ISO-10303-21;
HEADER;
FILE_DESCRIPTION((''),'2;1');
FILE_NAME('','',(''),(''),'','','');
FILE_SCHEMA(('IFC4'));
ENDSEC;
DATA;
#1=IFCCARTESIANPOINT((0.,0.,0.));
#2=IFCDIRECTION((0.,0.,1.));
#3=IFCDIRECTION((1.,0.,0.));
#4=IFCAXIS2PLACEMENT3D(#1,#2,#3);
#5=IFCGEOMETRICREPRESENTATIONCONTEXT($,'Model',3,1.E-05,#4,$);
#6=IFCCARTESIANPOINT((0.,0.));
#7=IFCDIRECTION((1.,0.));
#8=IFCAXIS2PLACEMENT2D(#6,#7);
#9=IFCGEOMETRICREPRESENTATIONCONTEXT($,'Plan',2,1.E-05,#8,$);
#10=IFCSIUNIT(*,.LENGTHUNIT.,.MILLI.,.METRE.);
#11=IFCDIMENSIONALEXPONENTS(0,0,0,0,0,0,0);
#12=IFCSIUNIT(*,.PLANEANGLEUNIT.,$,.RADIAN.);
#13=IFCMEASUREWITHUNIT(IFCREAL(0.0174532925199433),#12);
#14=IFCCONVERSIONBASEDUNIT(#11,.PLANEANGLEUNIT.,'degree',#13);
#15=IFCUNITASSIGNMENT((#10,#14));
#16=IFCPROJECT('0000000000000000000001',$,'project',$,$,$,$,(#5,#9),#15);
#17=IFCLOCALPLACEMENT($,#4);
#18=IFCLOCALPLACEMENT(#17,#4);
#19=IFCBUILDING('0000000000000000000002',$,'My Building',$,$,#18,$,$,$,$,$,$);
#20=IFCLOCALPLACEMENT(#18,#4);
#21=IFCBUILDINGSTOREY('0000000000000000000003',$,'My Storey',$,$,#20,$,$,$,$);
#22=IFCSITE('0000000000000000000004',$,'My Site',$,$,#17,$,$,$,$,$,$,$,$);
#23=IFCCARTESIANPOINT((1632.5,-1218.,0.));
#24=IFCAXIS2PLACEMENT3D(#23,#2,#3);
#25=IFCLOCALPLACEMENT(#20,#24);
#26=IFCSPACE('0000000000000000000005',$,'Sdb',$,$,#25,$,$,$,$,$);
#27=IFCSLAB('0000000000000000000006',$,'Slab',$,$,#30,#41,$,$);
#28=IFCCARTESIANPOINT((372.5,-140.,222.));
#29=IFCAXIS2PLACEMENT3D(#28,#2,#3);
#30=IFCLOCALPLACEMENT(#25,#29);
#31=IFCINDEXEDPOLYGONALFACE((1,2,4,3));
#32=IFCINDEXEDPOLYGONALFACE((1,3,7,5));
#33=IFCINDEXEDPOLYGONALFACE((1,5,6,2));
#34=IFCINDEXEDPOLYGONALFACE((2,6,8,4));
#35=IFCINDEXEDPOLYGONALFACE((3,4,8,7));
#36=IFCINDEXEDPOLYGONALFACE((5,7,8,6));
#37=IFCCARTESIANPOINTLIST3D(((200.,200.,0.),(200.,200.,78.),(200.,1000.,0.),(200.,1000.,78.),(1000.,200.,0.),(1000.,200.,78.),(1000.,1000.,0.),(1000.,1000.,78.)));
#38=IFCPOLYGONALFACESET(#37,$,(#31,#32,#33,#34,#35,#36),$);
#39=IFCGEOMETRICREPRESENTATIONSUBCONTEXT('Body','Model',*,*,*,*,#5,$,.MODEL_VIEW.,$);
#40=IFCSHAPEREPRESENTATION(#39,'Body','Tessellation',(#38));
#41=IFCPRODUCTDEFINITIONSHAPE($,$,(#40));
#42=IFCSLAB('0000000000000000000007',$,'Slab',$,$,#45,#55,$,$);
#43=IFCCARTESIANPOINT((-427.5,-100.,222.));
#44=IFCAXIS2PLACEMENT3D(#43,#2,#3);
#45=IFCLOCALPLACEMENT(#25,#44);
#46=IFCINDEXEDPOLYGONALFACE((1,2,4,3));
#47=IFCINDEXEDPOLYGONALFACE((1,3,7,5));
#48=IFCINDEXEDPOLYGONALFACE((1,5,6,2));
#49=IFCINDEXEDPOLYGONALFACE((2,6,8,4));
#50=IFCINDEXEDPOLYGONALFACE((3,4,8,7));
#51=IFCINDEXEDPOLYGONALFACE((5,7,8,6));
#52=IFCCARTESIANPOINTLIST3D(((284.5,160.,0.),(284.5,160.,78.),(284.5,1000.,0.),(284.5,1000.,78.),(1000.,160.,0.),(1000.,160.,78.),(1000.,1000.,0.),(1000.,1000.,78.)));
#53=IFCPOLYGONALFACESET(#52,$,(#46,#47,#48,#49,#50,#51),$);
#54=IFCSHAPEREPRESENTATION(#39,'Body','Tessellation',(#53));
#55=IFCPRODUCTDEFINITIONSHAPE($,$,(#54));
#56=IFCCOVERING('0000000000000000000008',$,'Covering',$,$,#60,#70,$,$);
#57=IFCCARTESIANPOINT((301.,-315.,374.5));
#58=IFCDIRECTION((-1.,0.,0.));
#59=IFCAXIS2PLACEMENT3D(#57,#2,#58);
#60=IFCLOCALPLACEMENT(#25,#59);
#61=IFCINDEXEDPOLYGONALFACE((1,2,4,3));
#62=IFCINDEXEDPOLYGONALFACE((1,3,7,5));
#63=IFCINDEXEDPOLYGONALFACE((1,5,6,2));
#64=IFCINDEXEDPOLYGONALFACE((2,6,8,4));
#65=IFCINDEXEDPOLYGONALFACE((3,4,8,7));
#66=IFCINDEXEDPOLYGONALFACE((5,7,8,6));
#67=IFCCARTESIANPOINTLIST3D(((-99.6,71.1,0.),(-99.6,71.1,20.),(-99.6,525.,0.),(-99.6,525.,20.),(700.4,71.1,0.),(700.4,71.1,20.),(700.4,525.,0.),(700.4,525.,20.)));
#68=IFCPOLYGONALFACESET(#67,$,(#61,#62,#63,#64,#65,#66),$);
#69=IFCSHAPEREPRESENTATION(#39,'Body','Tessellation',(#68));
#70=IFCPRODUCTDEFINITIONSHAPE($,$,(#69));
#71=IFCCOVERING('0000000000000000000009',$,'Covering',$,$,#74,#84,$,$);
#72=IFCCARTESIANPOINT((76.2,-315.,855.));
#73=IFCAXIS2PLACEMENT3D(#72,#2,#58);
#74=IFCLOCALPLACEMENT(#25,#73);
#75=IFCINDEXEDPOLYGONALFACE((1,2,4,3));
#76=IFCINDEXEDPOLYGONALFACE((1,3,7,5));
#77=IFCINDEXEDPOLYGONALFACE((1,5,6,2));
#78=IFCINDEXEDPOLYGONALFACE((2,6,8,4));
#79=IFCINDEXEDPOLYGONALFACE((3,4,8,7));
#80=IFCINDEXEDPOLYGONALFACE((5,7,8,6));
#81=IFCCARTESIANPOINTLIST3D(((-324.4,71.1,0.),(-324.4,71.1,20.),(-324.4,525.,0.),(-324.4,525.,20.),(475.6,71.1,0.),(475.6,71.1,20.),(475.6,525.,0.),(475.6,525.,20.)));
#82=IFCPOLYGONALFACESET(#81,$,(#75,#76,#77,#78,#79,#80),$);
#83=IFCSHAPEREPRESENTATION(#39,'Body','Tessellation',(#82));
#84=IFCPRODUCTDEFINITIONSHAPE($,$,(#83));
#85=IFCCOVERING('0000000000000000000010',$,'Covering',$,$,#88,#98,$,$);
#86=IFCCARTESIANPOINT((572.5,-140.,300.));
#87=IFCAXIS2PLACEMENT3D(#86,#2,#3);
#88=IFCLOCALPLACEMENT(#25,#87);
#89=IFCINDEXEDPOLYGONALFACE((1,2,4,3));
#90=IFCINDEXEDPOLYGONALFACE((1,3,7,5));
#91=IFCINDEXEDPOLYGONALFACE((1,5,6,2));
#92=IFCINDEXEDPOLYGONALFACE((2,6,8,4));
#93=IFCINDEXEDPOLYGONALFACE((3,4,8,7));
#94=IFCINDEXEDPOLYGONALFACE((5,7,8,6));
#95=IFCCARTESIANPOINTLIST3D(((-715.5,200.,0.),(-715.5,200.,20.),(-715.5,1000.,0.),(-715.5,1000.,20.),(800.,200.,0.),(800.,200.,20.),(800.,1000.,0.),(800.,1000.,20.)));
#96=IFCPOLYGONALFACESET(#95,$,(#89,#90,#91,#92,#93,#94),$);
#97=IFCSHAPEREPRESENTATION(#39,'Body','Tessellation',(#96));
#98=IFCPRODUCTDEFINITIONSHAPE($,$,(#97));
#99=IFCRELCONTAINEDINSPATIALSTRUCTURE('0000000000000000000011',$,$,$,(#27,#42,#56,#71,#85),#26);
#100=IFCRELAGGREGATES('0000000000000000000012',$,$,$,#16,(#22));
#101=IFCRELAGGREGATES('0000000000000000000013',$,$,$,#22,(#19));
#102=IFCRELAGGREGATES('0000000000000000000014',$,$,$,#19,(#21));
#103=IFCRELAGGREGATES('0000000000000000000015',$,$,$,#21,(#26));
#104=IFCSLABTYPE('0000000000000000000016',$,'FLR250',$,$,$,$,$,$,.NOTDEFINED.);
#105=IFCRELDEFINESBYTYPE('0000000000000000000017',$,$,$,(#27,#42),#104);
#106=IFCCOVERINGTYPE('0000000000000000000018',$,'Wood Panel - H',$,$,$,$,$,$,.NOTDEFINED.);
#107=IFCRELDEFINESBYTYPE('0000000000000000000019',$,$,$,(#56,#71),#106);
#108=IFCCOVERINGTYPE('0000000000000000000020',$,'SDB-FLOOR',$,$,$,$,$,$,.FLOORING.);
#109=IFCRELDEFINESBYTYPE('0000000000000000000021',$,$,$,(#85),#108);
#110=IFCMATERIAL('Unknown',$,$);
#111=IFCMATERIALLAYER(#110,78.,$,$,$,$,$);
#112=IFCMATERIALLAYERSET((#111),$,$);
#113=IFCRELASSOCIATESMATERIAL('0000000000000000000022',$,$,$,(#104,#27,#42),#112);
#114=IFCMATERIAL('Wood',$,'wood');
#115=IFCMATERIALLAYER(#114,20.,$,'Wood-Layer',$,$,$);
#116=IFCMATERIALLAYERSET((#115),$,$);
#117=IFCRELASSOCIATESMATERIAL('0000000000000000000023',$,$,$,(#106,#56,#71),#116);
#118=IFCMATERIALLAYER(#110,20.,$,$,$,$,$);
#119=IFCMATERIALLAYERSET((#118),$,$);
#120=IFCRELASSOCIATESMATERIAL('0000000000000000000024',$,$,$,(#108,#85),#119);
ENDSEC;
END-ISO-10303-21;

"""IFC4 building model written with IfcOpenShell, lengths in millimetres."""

from ifc_helpers import new_model, entity, si_unit, converted_unit, frame, origin_with_axes, origin_2d_with_axis, place, context, subcontext, project, spatial, line, indexed_curve, outline, extrude, material, layer, layer_set, layer_usage, type_object, element, save


model = new_model("IFC4")

# Units and contexts
model_context = context("Model", 3, precision=1e-05, world=origin_with_axes())
plan_context = context("Plan", 2, precision=1e-05, world=origin_2d_with_axis())
body_context = subcontext(model_context, "Body", "Model", "MODEL_VIEW")
ifc_project = project(units=[si_unit("LENGTHUNIT", "METRE", prefix="MILLI"), converted_unit("PLANEANGLEUNIT", "degree", entity("IfcReal", 0.0174532925199433), si_unit("PLANEANGLEUNIT", "RADIAN"), dimensions=[0, 0, 0, 0, 0, 0, 0])], contexts=[model_context, plan_context])

# Site, building, storey, space
site_placement = place(None, origin_with_axes())
site = spatial("IfcSite", under=ifc_project, at=site_placement, Name="My Site")
building_placement = place(site_placement, origin_with_axes())
building = spatial("IfcBuilding", under=site, at=building_placement, Name="My Building")
storey_placement = place(building_placement, origin_with_axes())
storey = spatial("IfcBuildingStorey", under=building, at=storey_placement, Name="My Storey")
space_placement = place(storey_placement, frame((1632.5, -1218.0, 0.0), z_axis=(0.0, 0.0, 1.0), x_axis=(1.0, 0.0, 0.0)))
space = spatial("IfcSpace", under=storey, at=space_placement, Name="Sdb")

# Slabs
ifc_material_1 = material(Name="Unknown")
ifc_layer_1 = layer(ifc_material_1, 78.0)
ifc_layer_set_1 = layer_set([ifc_layer_1])
ifc_layer_usage_1 = layer_usage(ifc_layer_set_1, "AXIS3", "POSITIVE", 0.0)
slab_type = type_object("IfcSlabType", Name="FLR250", PredefinedType="NOTDEFINED", material=ifc_layer_set_1)
slab_1_placement = place(space_placement, frame((372.5, -140.0, 222.0), z_axis=(0.0, 0.0, 1.0), x_axis=(1.0, 0.0, 0.0)))
element("IfcSlab", 1, at=slab_1_placement, inside=space, type_object=slab_type, material=ifc_layer_usage_1, Name="Slab", context=body_context, shape_type="SweptSolid", body=[
    extrude(outline(indexed_curve([(1000.0, 200.0), (200.0, 200.0), (200.0, 1000.0), (1000.0, 1000.0)], segments=[line(4, 1), line(1, 2), line(2, 3), line(3, 4)], self_intersect=False)), None, (0.0, 0.0, 1.0), 78.0),
])
ifc_layer_usage_2 = layer_usage(ifc_layer_set_1, "AXIS3", "POSITIVE", 0.0)
slab_2_placement = place(space_placement, frame((-427.5, -100.0, 222.0), z_axis=(0.0, 0.0, 1.0), x_axis=(1.0, 0.0, 0.0)))
element("IfcSlab", 2, at=slab_2_placement, inside=space, type_object=slab_type, material=ifc_layer_usage_2, Name="Slab", context=body_context, shape_type="SolidModel", body=[
    extrude(outline(indexed_curve([(284.5, 1000.0), (284.5, 160.0), (1000.0, 160.0), (1000.0, 1000.0), (284.5, 1000.0)])), None, (0.0, 0.0, 1.0), 78.0),
])

# Coverings
ifc_material_2 = material(Name="Wood", Category="wood")
ifc_layer_2 = layer(ifc_material_2, 20.0, Name="Wood-Layer")
ifc_layer_set_2 = layer_set([ifc_layer_2])
ifc_layer_usage_3 = layer_usage(ifc_layer_set_2, "AXIS3", "POSITIVE", 0.0)
covering_type_1 = type_object("IfcCoveringType", Name="Wood Panel - H", PredefinedType="NOTDEFINED", material=ifc_layer_set_2)
covering_1_placement = place(space_placement, frame((301.0, -315.0, 374.5), z_axis=(0.0, 0.0, 1.0), x_axis=(-1.0, 0.0, 0.0)))
element("IfcCovering", 3, at=covering_1_placement, inside=space, type_object=covering_type_1, material=ifc_layer_usage_3, Name="Covering", context=body_context, shape_type="SweptSolid", body=[
    extrude(outline(indexed_curve([(700.4, 525.0), (-99.6, 525.0), (-99.6, 71.1), (700.4, 71.1), (700.4, 525.0)])), None, (0.0, 0.0, 1.0), 20.0),
])
ifc_layer_usage_4 = layer_usage(ifc_layer_set_2, "AXIS3", "POSITIVE", 0.0)
covering_2_placement = place(space_placement, frame((76.2, -315.0, 855.0), z_axis=(0.0, 0.0, 1.0), x_axis=(-1.0, 0.0, 0.0)))
element("IfcCovering", 4, at=covering_2_placement, inside=space, type_object=covering_type_1, material=ifc_layer_usage_4, Name="Covering", context=body_context, shape_type="SweptSolid", body=[
    extrude(outline(indexed_curve([(-324.4, 525.0), (-324.4, 71.1), (475.6, 71.1), (475.6, 525.0), (-324.4, 525.0)])), None, (0.0, 0.0, 1.0), 20.0),
])

# Covering
ifc_layer_3 = layer(ifc_material_1, 20.0)
ifc_layer_set_3 = layer_set([ifc_layer_3])
ifc_layer_usage_5 = layer_usage(ifc_layer_set_3, "AXIS3", "POSITIVE", 0.0)
covering_type_2 = type_object("IfcCoveringType", Name="SDB-FLOOR", PredefinedType="FLOORING", material=ifc_layer_set_3)
covering_3_placement = place(space_placement, frame((572.5, -140.0, 300.0), z_axis=(0.0, 0.0, 1.0), x_axis=(1.0, 0.0, 0.0)))
element("IfcCovering", 5, at=covering_3_placement, inside=space, type_object=covering_type_2, material=ifc_layer_usage_5, Name="Covering", context=body_context, shape_type="SolidModel", body=[
    extrude(outline(indexed_curve([(-715.5, 1000.0), (-715.5, 200.0), (800.0, 200.0), (800.0, 1000.0), (-715.5, 1000.0)])), None, (0.0, 0.0, 1.0), 20.0),
])

save(model, "model.ifc")
